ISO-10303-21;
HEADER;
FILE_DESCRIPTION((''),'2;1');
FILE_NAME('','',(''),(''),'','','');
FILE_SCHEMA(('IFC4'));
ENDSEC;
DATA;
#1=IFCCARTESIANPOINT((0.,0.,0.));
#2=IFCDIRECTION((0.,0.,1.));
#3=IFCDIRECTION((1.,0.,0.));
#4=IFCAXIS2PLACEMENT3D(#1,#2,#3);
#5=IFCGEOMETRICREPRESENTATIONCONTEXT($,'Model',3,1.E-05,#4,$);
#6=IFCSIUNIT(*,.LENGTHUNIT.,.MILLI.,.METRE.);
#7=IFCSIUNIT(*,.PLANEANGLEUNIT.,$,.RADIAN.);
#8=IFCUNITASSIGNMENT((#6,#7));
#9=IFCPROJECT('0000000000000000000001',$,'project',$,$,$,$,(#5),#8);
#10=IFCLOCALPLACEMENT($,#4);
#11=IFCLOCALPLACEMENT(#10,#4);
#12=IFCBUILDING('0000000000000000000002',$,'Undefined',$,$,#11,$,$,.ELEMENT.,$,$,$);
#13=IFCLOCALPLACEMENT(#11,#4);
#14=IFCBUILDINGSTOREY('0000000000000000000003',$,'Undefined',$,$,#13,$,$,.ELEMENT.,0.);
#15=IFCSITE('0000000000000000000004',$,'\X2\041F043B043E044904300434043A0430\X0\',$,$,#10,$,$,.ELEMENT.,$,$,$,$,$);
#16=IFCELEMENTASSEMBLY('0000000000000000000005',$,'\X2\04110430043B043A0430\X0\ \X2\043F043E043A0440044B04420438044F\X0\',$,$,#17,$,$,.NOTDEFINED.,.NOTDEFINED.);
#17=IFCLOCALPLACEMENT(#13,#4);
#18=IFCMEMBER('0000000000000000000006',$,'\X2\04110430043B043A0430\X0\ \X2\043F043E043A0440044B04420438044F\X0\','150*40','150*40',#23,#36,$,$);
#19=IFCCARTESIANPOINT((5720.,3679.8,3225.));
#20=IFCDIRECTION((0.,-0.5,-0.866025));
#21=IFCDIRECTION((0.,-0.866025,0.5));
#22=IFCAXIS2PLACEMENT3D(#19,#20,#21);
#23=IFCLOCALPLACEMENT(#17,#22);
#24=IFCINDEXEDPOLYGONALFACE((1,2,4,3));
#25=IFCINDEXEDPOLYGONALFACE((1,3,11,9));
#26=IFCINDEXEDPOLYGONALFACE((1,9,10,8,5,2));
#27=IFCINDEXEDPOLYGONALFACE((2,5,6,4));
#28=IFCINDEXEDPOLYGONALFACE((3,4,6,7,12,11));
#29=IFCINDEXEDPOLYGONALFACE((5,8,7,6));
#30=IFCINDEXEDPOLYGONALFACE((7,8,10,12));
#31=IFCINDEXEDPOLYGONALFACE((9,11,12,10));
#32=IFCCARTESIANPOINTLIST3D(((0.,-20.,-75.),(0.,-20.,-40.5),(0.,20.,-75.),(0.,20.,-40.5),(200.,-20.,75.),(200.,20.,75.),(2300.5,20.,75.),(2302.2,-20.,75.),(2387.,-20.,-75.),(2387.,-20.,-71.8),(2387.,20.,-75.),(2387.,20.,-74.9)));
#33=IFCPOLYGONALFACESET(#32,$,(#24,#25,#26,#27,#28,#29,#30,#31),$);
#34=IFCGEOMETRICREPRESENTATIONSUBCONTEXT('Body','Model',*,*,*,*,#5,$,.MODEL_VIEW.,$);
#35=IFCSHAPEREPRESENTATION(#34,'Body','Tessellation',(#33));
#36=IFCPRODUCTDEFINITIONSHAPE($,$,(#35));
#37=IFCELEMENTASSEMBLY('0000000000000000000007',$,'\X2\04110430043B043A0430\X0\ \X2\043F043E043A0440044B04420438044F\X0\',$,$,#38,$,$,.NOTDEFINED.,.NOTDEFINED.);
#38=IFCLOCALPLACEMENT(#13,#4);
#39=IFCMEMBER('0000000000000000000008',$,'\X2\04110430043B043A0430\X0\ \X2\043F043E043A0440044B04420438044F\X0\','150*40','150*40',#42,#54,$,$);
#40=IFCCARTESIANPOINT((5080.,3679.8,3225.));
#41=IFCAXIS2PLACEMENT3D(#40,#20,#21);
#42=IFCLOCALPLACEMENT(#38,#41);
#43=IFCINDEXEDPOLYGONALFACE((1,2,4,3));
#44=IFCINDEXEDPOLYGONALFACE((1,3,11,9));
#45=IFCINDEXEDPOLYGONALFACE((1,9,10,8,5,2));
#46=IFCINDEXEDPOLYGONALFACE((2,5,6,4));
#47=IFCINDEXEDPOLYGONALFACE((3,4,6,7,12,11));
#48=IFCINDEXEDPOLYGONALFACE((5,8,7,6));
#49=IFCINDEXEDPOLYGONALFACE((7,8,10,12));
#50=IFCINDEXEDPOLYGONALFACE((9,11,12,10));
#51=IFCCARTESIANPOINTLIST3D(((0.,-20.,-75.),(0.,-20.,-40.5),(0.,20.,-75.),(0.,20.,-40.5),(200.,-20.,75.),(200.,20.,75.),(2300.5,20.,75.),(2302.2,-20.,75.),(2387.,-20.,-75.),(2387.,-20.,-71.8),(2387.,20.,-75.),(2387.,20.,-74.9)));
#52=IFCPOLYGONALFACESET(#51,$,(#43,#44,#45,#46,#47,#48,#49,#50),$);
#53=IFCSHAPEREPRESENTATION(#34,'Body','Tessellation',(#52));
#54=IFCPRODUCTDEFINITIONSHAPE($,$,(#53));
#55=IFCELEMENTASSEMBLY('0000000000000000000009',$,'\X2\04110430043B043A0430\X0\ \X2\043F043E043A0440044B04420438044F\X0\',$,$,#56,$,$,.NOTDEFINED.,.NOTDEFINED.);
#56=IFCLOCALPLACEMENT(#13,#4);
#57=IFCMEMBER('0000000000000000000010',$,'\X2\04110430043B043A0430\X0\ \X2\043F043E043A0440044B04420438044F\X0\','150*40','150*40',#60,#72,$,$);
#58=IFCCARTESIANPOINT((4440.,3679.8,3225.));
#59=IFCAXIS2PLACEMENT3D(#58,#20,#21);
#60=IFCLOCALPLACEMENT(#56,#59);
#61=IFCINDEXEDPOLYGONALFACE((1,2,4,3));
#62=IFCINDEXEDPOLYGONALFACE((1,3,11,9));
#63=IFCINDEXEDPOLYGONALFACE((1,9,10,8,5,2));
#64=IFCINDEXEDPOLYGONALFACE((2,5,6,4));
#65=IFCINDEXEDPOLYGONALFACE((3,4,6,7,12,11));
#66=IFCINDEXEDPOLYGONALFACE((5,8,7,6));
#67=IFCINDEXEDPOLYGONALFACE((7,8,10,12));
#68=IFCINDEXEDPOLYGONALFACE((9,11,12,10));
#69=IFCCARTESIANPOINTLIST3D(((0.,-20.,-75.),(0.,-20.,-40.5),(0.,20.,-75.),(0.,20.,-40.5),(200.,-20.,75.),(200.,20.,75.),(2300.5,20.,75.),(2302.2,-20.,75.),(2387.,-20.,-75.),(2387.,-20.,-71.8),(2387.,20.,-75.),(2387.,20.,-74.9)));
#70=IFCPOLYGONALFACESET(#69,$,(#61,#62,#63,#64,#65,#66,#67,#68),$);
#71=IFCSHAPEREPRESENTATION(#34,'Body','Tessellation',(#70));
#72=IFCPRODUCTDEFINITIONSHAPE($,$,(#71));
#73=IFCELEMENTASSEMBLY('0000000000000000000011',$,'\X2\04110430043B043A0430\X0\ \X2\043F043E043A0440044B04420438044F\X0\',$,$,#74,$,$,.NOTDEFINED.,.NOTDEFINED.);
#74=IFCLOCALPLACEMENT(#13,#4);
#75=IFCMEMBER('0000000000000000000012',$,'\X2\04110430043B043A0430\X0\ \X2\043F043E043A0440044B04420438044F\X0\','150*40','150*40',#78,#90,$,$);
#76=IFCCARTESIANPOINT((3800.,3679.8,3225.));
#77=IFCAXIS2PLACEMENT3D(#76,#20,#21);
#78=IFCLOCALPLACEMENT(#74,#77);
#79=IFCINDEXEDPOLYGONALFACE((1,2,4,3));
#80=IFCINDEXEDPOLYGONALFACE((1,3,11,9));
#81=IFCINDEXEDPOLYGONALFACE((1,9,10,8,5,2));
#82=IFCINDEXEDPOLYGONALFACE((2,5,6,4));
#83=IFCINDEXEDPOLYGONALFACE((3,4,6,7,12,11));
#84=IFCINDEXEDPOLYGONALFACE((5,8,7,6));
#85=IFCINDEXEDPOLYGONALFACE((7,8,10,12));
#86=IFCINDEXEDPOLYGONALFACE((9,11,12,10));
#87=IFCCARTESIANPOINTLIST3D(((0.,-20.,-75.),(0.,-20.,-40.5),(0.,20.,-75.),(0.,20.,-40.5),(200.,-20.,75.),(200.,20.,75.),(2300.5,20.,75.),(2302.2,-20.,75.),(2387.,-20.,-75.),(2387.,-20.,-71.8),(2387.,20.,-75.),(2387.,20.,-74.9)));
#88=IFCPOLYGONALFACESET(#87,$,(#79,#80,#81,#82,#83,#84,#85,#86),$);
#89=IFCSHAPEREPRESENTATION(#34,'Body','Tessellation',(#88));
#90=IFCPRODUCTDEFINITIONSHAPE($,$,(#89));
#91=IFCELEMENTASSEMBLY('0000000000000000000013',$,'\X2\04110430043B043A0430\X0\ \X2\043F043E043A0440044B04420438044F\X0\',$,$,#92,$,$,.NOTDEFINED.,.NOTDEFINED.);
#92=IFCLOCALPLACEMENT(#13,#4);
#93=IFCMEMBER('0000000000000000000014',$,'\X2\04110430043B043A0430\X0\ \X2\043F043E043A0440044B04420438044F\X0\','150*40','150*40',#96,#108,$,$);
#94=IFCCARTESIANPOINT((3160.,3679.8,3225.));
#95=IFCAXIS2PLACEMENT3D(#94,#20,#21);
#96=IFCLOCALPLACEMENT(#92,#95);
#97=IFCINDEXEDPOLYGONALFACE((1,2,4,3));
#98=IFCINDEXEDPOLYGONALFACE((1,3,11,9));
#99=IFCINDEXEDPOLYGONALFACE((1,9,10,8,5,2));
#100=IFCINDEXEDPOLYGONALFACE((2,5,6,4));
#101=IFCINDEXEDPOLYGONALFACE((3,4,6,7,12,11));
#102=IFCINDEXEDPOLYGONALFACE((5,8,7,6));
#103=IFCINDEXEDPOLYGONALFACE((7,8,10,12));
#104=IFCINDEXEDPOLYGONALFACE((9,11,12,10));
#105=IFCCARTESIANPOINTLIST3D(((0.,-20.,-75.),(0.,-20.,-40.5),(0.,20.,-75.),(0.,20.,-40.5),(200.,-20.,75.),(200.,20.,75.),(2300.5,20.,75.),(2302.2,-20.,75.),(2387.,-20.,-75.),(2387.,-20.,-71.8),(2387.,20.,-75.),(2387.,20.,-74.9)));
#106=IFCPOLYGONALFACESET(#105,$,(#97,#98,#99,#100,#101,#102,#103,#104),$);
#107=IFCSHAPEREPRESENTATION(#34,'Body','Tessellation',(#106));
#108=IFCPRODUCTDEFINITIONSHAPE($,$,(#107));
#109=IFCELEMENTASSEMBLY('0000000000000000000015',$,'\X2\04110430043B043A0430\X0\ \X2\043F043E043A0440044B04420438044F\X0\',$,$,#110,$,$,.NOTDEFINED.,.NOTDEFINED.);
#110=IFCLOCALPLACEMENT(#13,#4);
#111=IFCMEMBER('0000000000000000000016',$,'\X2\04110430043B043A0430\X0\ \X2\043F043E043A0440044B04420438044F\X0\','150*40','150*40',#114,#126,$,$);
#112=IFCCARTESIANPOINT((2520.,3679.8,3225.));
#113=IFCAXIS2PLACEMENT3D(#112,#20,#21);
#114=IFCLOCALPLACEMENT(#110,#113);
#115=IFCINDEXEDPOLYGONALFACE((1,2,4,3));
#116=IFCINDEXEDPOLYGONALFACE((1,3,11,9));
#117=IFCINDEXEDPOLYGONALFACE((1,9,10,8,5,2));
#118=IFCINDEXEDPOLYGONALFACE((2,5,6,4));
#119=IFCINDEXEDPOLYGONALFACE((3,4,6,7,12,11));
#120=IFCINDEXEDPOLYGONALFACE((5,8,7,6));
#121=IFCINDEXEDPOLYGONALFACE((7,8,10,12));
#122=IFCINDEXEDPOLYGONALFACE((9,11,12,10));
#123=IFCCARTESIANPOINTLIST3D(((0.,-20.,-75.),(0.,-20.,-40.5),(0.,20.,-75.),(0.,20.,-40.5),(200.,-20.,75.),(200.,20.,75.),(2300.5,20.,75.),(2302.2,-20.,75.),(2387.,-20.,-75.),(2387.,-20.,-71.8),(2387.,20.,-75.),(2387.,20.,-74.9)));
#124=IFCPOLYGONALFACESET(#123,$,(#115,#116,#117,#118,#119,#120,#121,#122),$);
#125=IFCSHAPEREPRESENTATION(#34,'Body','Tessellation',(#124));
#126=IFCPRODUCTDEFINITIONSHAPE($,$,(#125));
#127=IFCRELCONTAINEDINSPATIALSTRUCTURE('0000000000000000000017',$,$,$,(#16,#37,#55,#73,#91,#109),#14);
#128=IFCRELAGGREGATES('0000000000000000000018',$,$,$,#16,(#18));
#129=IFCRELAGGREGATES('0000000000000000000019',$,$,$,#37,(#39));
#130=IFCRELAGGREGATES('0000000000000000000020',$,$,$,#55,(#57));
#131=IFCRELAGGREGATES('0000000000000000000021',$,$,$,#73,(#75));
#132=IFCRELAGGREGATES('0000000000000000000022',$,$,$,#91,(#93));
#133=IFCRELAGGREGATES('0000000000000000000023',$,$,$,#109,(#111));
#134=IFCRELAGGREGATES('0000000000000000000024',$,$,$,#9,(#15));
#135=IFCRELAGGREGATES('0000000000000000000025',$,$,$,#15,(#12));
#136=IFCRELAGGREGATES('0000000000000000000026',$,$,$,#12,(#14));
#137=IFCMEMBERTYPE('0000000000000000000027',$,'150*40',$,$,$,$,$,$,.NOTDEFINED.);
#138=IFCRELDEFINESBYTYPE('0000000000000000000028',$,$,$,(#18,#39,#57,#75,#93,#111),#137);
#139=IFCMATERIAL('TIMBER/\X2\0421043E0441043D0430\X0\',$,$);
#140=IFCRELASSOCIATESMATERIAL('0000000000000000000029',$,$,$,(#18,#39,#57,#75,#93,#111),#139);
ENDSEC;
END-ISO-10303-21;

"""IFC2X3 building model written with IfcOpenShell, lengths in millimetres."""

from ifc_helpers import new_model, si_unit, frame, origin_with_axes, origin_2d_with_axis, place, context, subcontext, project, spatial, rectangle, extrude, boolean, halfspace, material, type_object, element, aggregate, save


model = new_model("IFC2X3")

# Units and contexts
model_context = context("Model", 3, precision=1e-05, world=origin_with_axes())
body_context = subcontext(model_context, "Body", "Model", "MODEL_VIEW")
ifc_project = project(units=[si_unit("LENGTHUNIT", "METRE", prefix="MILLI"), si_unit("PLANEANGLEUNIT", "RADIAN")], contexts=[model_context])

# Site, building, storey
site_placement = place(None, origin_with_axes())
site = spatial("IfcSite", under=ifc_project, at=site_placement, Name="Площадка", CompositionType="ELEMENT")
building_placement = place(site_placement, origin_with_axes())
building = spatial("IfcBuilding", under=site, at=building_placement, Name="Undefined", CompositionType="ELEMENT")
storey_placement = place(building_placement, origin_with_axes())
storey = spatial("IfcBuildingStorey", under=building, at=storey_placement, Name="Undefined", CompositionType="ELEMENT", Elevation=0.0)

# Element assemblies, members
assembly_1_placement = place(storey_placement, origin_with_axes())
assembly_1 = element("IfcElementAssembly", 1, at=assembly_1_placement, inside=storey, Name="Балка покрытия", AssemblyPlace="NOTDEFINED", PredefinedType="NOTDEFINED")
ifc_material = material(Name="TIMBER/Сосна")
member_type = type_object("IfcMemberType", Name="150*40", PredefinedType="NOTDEFINED")
member_1_placement = place(assembly_1_placement, frame((5720.0, 3679.8, 3225.0), z_axis=(0.0, -0.5, -0.866025), x_axis=(0.0, -0.866025, 0.5)))
member_1 = element("IfcMember", 2, at=member_1_placement, type_object=member_type, material=ifc_material, Name="Балка покрытия", Description="150*40", ObjectType="150*40", context=body_context, shape_type="CSG", body=[
    boolean("DIFFERENCE", boolean("DIFFERENCE", extrude(rectangle(XDim=40.0, YDim=150.0, at=origin_2d_with_axis()), frame((2387.0, 0.0, 0.0), z_axis=(-1.0, 0.0, 0.0), x_axis=(0.0, -1.0, 0.0)), (0.0, 0.0, 1.0), 2387.0), extrude(rectangle(XDim=40.0, YDim=150.0, at=origin_2d_with_axis()), frame((3513.2, 0.0, 2074.5), z_axis=(-0.866025, 0.0, -0.5), x_axis=(0.0, -1.0, 0.0)), (0.0, 0.0, 1.0), 4100.0)), halfspace(frame((2300.5, 20.0, 75.0), z_axis=(0.86539, 0.038305, 0.499633), x_axis=(0.5, 0.0, -0.866025)), False)),
])
aggregate(assembly_1, [member_1])
assembly_2_placement = place(storey_placement, origin_with_axes())
assembly_2 = element("IfcElementAssembly", 3, at=assembly_2_placement, inside=storey, Name="Балка покрытия", AssemblyPlace="NOTDEFINED", PredefinedType="NOTDEFINED")
member_2_placement = place(assembly_2_placement, frame((5080.0, 3679.8, 3225.0), z_axis=(0.0, -0.5, -0.866025), x_axis=(0.0, -0.866025, 0.5)))
member_2 = element("IfcMember", 4, at=member_2_placement, type_object=member_type, material=ifc_material, Name="Балка покрытия", Description="150*40", ObjectType="150*40", context=body_context, shape_type="CSG", body=[
    boolean("DIFFERENCE", boolean("DIFFERENCE", extrude(rectangle(XDim=40.0, YDim=150.0, at=origin_2d_with_axis()), frame((2387.0, 0.0, 0.0), z_axis=(-1.0, 0.0, 0.0), x_axis=(0.0, -1.0, 0.0)), (0.0, 0.0, 1.0), 2387.0), extrude(rectangle(XDim=40.0, YDim=150.0, at=origin_2d_with_axis()), frame((3513.2, 0.0, 2074.5), z_axis=(-0.866025, 0.0, -0.5), x_axis=(0.0, -1.0, 0.0)), (0.0, 0.0, 1.0), 4100.0)), halfspace(frame((2300.5, 20.0, 75.0), z_axis=(0.86539, 0.038305, 0.499633), x_axis=(0.5, 0.0, -0.866025)), False)),
])
aggregate(assembly_2, [member_2])
assembly_3_placement = place(storey_placement, origin_with_axes())
assembly_3 = element("IfcElementAssembly", 5, at=assembly_3_placement, inside=storey, Name="Балка покрытия", AssemblyPlace="NOTDEFINED", PredefinedType="NOTDEFINED")
member_3_placement = place(assembly_3_placement, frame((4440.0, 3679.8, 3225.0), z_axis=(0.0, -0.5, -0.866025), x_axis=(0.0, -0.866025, 0.5)))
member_3 = element("IfcMember", 6, at=member_3_placement, type_object=member_type, material=ifc_material, Name="Балка покрытия", Description="150*40", ObjectType="150*40", context=body_context, shape_type="CSG", body=[
    boolean("DIFFERENCE", boolean("DIFFERENCE", extrude(rectangle(XDim=40.0, YDim=150.0, at=origin_2d_with_axis()), frame((2387.0, 0.0, 0.0), z_axis=(-1.0, 0.0, 0.0), x_axis=(0.0, -1.0, 0.0)), (0.0, 0.0, 1.0), 2387.0), extrude(rectangle(XDim=40.0, YDim=150.0, at=origin_2d_with_axis()), frame((3513.2, 0.0, 2074.5), z_axis=(-0.866025, 0.0, -0.5), x_axis=(0.0, -1.0, 0.0)), (0.0, 0.0, 1.0), 4100.0)), halfspace(frame((2300.5, 20.0, 75.0), z_axis=(0.86539, 0.038305, 0.499633), x_axis=(0.5, 0.0, -0.866025)), False)),
])
aggregate(assembly_3, [member_3])
assembly_4_placement = place(storey_placement, origin_with_axes())
assembly_4 = element("IfcElementAssembly", 7, at=assembly_4_placement, inside=storey, Name="Балка покрытия", AssemblyPlace="NOTDEFINED", PredefinedType="NOTDEFINED")
member_4_placement = place(assembly_4_placement, frame((3800.0, 3679.8, 3225.0), z_axis=(0.0, -0.5, -0.866025), x_axis=(0.0, -0.866025, 0.5)))
member_4 = element("IfcMember", 8, at=member_4_placement, type_object=member_type, material=ifc_material, Name="Балка покрытия", Description="150*40", ObjectType="150*40", context=body_context, shape_type="CSG", body=[
    boolean("DIFFERENCE", boolean("DIFFERENCE", extrude(rectangle(XDim=40.0, YDim=150.0, at=origin_2d_with_axis()), frame((2387.0, 0.0, 0.0), z_axis=(-1.0, 0.0, 0.0), x_axis=(0.0, -1.0, 0.0)), (0.0, 0.0, 1.0), 2387.0), extrude(rectangle(XDim=40.0, YDim=150.0, at=origin_2d_with_axis()), frame((3513.2, 0.0, 2074.5), z_axis=(-0.866025, 0.0, -0.5), x_axis=(0.0, -1.0, 0.0)), (0.0, 0.0, 1.0), 4100.0)), halfspace(frame((2300.5, 20.0, 75.0), z_axis=(0.86539, 0.038305, 0.499633), x_axis=(0.5, 0.0, -0.866025)), False)),
])
aggregate(assembly_4, [member_4])
assembly_5_placement = place(storey_placement, origin_with_axes())
assembly_5 = element("IfcElementAssembly", 9, at=assembly_5_placement, inside=storey, Name="Балка покрытия", AssemblyPlace="NOTDEFINED", PredefinedType="NOTDEFINED")
member_5_placement = place(assembly_5_placement, frame((3160.0, 3679.8, 3225.0), z_axis=(0.0, -0.5, -0.866025), x_axis=(0.0, -0.866025, 0.5)))
member_5 = element("IfcMember", 10, at=member_5_placement, type_object=member_type, material=ifc_material, Name="Балка покрытия", Description="150*40", ObjectType="150*40", context=body_context, shape_type="CSG", body=[
    boolean("DIFFERENCE", boolean("DIFFERENCE", extrude(rectangle(XDim=40.0, YDim=150.0, at=origin_2d_with_axis()), frame((2387.0, 0.0, 0.0), z_axis=(-1.0, 0.0, 0.0), x_axis=(0.0, -1.0, 0.0)), (0.0, 0.0, 1.0), 2387.0), extrude(rectangle(XDim=40.0, YDim=150.0, at=origin_2d_with_axis()), frame((3513.2, 0.0, 2074.5), z_axis=(-0.866025, 0.0, -0.5), x_axis=(0.0, -1.0, 0.0)), (0.0, 0.0, 1.0), 4100.0)), halfspace(frame((2300.5, 20.0, 75.0), z_axis=(0.86539, 0.038305, 0.499633), x_axis=(0.5, 0.0, -0.866025)), False)),
])
aggregate(assembly_5, [member_5])
assembly_6_placement = place(storey_placement, origin_with_axes())
assembly_6 = element("IfcElementAssembly", 11, at=assembly_6_placement, inside=storey, Name="Балка покрытия", AssemblyPlace="NOTDEFINED", PredefinedType="NOTDEFINED")
member_6_placement = place(assembly_6_placement, frame((2520.0, 3679.8, 3225.0), z_axis=(0.0, -0.5, -0.866025), x_axis=(0.0, -0.866025, 0.5)))
member_6 = element("IfcMember", 12, at=member_6_placement, type_object=member_type, material=ifc_material, Name="Балка покрытия", Description="150*40", ObjectType="150*40", context=body_context, shape_type="CSG", body=[
    boolean("DIFFERENCE", boolean("DIFFERENCE", extrude(rectangle(XDim=40.0, YDim=150.0, at=origin_2d_with_axis()), frame((2387.0, 0.0, 0.0), z_axis=(-1.0, 0.0, 0.0), x_axis=(0.0, -1.0, 0.0)), (0.0, 0.0, 1.0), 2387.0), extrude(rectangle(XDim=40.0, YDim=150.0, at=origin_2d_with_axis()), frame((3513.2, 0.0, 2074.5), z_axis=(-0.866025, 0.0, -0.5), x_axis=(0.0, -1.0, 0.0)), (0.0, 0.0, 1.0), 4100.0)), halfspace(frame((2300.5, 20.0, 75.0), z_axis=(0.86539, 0.038305, 0.499633), x_axis=(0.5, 0.0, -0.866025)), False)),
])
aggregate(assembly_6, [member_6])

save(model, "model.ifc")
